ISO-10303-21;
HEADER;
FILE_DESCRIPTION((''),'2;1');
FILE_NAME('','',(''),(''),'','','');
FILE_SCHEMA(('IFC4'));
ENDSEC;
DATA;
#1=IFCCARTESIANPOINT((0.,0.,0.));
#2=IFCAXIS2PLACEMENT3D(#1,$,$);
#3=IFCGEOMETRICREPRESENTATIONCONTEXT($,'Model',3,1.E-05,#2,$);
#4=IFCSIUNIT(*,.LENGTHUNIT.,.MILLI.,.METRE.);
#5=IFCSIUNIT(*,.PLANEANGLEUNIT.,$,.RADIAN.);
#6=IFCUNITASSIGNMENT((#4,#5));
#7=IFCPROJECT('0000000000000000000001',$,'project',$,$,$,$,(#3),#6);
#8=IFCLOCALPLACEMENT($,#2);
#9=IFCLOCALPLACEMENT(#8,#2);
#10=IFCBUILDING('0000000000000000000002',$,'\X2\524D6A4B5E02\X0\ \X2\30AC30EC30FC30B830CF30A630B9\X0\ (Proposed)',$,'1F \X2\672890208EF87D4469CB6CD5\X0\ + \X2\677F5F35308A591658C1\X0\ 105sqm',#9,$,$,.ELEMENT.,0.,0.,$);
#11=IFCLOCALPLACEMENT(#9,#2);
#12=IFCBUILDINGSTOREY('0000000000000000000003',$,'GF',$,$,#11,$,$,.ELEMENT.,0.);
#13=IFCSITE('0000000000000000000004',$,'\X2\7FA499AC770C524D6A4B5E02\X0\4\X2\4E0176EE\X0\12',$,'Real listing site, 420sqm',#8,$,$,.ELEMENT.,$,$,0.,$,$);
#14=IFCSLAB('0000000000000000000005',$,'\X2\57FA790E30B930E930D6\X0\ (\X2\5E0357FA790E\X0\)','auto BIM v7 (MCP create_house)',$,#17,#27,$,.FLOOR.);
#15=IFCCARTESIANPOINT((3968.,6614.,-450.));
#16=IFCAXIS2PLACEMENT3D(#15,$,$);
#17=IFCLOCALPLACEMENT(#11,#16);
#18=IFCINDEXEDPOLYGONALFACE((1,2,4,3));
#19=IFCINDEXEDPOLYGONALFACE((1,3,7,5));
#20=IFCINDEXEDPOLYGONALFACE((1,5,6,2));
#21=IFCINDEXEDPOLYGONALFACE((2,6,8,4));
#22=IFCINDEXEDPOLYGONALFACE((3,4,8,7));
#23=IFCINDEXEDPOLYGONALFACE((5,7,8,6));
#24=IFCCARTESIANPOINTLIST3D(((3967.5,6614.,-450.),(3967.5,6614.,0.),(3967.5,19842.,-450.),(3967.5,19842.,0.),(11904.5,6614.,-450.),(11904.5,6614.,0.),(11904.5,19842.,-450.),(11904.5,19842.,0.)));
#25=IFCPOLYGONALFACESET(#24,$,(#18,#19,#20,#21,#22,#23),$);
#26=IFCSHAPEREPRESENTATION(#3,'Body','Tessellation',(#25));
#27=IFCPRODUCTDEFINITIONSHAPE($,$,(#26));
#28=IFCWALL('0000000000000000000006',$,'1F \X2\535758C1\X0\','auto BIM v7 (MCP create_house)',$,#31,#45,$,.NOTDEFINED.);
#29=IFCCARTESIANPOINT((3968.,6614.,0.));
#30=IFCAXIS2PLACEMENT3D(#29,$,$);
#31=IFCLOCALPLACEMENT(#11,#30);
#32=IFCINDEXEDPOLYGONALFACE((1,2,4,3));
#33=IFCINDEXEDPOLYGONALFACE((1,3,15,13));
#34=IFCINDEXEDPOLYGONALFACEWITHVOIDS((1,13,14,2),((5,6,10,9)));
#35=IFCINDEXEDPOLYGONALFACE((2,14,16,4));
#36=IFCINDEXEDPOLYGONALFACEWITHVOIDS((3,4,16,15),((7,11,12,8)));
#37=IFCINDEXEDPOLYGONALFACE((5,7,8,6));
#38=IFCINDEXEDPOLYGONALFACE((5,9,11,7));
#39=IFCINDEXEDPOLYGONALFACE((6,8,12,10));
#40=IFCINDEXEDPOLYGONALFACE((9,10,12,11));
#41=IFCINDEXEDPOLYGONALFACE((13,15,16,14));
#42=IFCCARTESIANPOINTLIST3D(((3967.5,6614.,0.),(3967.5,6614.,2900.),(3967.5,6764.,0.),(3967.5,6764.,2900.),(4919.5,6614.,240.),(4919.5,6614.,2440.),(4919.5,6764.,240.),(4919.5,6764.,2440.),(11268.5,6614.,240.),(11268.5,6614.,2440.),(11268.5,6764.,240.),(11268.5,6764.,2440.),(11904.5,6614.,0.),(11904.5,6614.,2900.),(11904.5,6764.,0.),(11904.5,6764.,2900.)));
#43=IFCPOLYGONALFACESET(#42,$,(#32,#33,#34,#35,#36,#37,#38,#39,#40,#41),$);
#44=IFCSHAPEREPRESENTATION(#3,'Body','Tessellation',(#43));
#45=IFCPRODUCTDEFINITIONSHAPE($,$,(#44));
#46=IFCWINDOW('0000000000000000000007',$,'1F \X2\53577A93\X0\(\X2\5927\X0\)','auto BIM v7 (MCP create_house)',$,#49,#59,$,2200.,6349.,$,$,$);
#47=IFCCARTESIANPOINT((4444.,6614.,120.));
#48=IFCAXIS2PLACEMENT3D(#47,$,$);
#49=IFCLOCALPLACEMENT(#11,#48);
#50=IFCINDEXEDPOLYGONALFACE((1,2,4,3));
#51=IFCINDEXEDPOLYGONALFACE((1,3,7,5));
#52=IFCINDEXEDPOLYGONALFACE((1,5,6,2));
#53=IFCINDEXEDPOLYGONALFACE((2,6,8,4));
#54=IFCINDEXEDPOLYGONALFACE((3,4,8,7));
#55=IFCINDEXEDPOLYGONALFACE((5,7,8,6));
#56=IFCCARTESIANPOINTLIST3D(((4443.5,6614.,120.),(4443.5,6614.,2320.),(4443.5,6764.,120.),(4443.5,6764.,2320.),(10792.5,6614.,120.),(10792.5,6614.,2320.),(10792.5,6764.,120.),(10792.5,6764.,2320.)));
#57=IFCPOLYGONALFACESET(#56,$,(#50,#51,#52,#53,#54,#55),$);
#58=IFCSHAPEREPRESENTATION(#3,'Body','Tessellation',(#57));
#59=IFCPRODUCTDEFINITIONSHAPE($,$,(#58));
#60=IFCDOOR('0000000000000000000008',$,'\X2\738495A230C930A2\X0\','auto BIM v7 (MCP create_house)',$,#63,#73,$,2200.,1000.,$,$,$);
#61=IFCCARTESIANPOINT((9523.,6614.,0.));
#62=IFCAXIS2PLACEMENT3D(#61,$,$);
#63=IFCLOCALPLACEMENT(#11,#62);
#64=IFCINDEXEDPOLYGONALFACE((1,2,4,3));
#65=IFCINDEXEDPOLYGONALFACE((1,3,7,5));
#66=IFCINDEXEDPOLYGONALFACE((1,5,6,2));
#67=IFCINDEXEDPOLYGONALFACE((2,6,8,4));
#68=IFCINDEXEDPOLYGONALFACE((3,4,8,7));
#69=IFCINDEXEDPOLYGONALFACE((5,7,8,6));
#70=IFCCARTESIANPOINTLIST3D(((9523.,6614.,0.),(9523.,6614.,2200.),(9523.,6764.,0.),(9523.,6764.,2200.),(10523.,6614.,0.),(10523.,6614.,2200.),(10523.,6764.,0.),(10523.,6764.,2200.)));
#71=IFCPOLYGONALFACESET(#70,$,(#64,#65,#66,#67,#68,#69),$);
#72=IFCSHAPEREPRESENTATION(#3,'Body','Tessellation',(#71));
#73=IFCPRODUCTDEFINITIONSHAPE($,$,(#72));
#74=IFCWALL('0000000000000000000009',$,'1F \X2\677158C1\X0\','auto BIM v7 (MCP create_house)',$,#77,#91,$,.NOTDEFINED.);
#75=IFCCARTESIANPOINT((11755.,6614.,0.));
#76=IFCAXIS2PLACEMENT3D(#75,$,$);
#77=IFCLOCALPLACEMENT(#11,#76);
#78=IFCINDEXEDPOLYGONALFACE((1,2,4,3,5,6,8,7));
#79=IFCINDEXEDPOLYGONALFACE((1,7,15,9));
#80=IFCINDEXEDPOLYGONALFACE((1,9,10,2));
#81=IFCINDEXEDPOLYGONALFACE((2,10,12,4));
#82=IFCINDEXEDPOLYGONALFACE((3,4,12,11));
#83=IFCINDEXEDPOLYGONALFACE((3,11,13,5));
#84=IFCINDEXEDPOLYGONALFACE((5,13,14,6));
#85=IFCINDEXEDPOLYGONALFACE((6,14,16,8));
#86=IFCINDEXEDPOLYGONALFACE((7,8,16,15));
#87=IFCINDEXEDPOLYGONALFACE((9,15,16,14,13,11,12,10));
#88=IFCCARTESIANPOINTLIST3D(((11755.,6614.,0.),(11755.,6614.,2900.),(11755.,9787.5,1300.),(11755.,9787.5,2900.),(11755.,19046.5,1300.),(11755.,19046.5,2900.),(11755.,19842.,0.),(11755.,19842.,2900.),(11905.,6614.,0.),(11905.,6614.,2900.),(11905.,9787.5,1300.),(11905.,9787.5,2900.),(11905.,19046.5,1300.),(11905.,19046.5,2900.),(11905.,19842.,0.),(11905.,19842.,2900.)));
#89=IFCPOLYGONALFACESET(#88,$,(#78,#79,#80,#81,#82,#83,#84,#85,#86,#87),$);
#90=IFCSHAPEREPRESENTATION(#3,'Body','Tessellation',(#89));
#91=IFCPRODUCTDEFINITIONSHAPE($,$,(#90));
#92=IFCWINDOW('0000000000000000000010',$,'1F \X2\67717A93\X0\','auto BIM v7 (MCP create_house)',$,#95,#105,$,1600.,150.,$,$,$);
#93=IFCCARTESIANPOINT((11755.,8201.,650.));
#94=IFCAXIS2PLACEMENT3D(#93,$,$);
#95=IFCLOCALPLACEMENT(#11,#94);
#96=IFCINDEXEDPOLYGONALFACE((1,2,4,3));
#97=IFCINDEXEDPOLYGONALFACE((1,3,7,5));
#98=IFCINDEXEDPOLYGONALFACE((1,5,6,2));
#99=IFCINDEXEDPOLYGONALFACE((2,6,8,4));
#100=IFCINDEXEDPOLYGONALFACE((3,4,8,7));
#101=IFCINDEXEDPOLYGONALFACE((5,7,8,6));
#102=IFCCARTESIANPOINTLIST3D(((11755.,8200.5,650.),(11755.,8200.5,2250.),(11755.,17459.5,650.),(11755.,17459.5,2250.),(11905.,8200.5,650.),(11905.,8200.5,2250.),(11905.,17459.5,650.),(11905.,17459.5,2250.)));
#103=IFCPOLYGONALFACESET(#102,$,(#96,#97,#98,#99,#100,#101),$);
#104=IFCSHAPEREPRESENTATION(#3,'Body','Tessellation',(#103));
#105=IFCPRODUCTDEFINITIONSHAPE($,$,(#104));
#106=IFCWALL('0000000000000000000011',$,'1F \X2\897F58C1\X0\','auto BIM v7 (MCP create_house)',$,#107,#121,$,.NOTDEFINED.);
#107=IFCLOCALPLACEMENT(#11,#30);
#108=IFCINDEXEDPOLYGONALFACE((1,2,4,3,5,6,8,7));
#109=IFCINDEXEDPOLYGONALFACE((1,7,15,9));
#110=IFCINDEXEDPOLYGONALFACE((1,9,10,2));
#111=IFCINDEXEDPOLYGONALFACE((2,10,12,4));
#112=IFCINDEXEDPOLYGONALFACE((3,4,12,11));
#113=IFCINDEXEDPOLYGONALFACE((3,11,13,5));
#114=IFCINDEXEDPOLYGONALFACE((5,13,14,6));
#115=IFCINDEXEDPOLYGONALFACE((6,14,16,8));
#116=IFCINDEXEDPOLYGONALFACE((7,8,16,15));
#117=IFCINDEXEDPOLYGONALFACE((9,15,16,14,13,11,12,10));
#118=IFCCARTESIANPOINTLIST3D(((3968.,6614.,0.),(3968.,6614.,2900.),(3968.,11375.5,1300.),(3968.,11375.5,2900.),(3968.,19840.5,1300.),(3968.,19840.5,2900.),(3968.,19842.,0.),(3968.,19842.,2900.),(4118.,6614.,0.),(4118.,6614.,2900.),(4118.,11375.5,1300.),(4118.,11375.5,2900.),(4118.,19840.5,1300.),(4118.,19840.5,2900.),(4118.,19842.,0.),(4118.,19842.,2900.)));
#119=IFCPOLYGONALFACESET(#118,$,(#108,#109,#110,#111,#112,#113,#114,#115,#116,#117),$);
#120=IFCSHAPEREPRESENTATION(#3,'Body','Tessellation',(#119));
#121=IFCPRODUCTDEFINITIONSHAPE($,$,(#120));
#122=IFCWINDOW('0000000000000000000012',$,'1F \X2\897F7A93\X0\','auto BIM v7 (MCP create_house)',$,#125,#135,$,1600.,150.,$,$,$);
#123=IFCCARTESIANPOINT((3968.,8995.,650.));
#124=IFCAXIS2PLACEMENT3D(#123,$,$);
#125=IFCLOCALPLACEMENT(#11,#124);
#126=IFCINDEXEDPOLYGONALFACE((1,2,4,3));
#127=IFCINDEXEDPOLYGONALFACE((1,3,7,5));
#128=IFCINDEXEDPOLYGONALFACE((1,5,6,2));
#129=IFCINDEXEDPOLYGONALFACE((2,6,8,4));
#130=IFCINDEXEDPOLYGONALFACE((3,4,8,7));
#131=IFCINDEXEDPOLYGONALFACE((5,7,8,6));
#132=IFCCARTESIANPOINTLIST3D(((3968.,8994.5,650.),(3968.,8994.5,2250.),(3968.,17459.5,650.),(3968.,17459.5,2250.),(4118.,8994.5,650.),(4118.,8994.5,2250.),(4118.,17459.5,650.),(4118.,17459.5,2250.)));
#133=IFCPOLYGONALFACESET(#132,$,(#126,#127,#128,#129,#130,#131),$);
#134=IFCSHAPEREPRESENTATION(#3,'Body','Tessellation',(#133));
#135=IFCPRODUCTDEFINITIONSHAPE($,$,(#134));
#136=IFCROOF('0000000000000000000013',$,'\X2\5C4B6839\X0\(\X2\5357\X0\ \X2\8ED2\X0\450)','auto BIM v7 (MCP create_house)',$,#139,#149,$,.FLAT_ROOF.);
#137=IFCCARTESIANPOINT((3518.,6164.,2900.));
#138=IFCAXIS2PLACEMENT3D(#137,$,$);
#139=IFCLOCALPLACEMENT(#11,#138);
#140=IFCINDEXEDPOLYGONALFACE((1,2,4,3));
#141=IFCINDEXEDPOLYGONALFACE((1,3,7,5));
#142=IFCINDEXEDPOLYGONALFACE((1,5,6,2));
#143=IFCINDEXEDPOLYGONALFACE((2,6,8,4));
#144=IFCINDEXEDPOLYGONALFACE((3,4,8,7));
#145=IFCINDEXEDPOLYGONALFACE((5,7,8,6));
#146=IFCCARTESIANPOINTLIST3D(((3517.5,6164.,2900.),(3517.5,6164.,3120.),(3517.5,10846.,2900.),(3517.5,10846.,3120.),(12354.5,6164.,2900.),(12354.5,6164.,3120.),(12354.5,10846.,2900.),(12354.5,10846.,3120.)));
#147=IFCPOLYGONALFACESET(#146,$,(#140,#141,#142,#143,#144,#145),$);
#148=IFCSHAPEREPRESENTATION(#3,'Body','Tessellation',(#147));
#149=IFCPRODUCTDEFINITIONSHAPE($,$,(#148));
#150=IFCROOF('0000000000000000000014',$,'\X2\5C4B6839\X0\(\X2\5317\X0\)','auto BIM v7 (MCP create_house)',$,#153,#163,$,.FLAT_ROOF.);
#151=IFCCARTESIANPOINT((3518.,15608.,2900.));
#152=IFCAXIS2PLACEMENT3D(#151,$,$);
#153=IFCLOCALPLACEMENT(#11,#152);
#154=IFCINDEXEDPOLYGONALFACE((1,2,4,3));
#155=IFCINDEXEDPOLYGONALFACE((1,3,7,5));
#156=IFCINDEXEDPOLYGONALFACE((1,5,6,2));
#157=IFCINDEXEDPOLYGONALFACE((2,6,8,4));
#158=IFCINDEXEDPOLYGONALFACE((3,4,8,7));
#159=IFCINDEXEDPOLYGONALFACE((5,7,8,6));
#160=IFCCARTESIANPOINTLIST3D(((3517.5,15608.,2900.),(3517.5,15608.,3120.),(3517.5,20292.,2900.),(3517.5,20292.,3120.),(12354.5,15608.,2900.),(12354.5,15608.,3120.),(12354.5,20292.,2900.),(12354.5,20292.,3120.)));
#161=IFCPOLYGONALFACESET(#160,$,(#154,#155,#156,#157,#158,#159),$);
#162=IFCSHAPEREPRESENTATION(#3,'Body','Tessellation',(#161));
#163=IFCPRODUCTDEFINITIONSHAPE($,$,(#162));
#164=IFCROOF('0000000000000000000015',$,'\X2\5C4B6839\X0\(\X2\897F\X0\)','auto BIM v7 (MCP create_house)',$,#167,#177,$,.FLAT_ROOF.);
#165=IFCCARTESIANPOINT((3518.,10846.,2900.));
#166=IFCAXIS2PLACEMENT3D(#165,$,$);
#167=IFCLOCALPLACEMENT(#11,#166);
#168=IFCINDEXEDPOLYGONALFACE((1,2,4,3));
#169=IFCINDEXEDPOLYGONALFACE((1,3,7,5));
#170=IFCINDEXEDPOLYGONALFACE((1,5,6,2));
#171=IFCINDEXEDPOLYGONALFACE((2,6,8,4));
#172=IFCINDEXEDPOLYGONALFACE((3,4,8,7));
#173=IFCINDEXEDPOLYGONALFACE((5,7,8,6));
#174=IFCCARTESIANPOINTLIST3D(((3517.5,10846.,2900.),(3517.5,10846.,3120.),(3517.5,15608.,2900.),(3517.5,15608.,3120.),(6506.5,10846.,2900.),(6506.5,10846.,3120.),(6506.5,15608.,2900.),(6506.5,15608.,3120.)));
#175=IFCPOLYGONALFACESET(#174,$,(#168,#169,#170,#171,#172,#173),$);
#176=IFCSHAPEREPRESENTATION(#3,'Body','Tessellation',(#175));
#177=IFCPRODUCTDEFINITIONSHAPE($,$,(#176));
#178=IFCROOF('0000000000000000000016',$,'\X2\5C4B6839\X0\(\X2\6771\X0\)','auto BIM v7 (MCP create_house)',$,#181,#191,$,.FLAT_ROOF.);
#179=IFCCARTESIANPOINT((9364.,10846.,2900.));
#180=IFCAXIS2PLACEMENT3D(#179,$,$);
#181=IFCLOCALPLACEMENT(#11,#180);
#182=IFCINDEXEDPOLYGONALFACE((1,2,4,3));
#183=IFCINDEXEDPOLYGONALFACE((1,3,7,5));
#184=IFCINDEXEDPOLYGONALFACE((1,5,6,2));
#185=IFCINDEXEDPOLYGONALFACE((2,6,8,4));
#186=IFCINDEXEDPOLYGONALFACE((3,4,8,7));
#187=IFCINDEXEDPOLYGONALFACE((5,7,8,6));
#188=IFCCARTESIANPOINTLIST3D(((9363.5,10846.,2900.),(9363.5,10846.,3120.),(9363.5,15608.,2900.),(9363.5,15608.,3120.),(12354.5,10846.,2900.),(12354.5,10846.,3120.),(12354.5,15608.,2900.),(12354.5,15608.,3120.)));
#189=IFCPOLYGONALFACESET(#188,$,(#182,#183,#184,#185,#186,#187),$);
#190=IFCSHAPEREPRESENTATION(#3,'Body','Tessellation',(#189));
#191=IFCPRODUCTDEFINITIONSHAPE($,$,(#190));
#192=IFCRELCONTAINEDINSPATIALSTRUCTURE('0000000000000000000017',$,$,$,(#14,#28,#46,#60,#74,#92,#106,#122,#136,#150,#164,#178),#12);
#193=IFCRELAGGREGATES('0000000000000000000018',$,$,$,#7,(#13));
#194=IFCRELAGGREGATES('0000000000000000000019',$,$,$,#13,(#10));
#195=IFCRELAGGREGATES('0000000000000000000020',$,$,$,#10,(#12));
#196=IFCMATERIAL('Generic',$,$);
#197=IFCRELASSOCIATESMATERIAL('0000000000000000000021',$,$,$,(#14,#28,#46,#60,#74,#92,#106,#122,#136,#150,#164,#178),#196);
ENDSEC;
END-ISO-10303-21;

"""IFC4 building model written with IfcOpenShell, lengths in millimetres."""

from ifc_helpers import new_model, si_unit, frame, frame_2d, origin, place, context, project, spatial, rectangle, extrude, material, element, fill, save


model = new_model("IFC4")

# Units and contexts
model_context = context("Model", 3, precision=1e-05, world=origin())
ifc_project = project(units=[si_unit("LENGTHUNIT", "METRE", prefix="MILLI"), si_unit("PLANEANGLEUNIT", "RADIAN")], contexts=[model_context])

# Site, building, storey
site_placement = place(None, origin())
site = spatial("IfcSite", under=ifc_project, at=site_placement, Name="群馬県前橋市4丁目12", ObjectType="Real listing site, 420sqm", CompositionType="ELEMENT", RefElevation=0.0)
building_placement = place(site_placement, origin())
building = spatial("IfcBuilding", under=site, at=building_placement, Name="前橋市 ガレージハウス (Proposed)", ObjectType="1F 木造軸組構法 + 板張り外壁 105sqm", CompositionType="ELEMENT", ElevationOfRefHeight=0.0, ElevationOfTerrain=0.0)
storey_placement = place(building_placement, origin())
storey = spatial("IfcBuildingStorey", under=building, at=storey_placement, Name="GF", CompositionType="ELEMENT", Elevation=0.0)

# Slab
ifc_material = material(Name="Generic")
slab_1_placement = place(storey_placement, frame((3968.0, 6614.0, -450.0)))
element("IfcSlab", 1, at=slab_1_placement, inside=storey, material=ifc_material, Name="基礎スラブ (布基礎)", Description="auto BIM v7 (MCP create_house)", PredefinedType="FLOOR", context=model_context, shape_type="SweptSolid", body=[
    extrude(rectangle(XDim=7937.0, YDim=13228.0, at=frame_2d((3968.0, 6614.0))), frame((3968.0, 6614.0, -450.0)), (0.0, 0.0, 1.0), 450.0),
])

# Wall, openings, window, door
wall_1_placement = place(storey_placement, frame((3968.0, 6614.0, 0.0)))
wall_1 = element("IfcWall", 2, at=wall_1_placement, inside=storey, material=ifc_material, Name="1F 南壁", Description="auto BIM v7 (MCP create_house)", PredefinedType="NOTDEFINED", context=model_context, shape_type="SweptSolid", body=[
    extrude(rectangle(XDim=7937.0, YDim=150.0, at=frame_2d((3968.0, 75.0))), frame((3968.0, 6614.0, 0.0)), (0.0, 0.0, 1.0), 2900.0),
])
opening_1_placement = place(storey_placement, frame((4444.0, 6614.0, 120.0)))
opening_1 = element("IfcOpeningElement", 3, at=opening_1_placement, cuts=wall_1, PredefinedType="NOTDEFINED", context=model_context, shape_type="SweptSolid", body=[
    extrude(rectangle(XDim=6349.0, YDim=150.0, at=frame_2d((3174.0, 75.0))), frame((4444.0, 6614.0, 120.0)), (0.0, 0.0, 1.0), 2200.0),
])
opening_2_placement = place(storey_placement, frame((9523.0, 6614.0, 0.0)))
opening_2 = element("IfcOpeningElement", 4, at=opening_2_placement, cuts=wall_1, PredefinedType="NOTDEFINED", context=model_context, shape_type="SweptSolid", body=[
    extrude(rectangle(XDim=1000.0, YDim=150.0, at=frame_2d((500.0, 75.0))), frame((9523.0, 6614.0, 0.0)), (0.0, 0.0, 1.0), 2200.0),
])
window_1_placement = place(storey_placement, frame((4444.0, 6614.0, 120.0)))
window_1 = element("IfcWindow", 5, at=window_1_placement, inside=storey, material=ifc_material, Name="1F 南窓(大)", Description="auto BIM v7 (MCP create_house)", OverallHeight=2200.0, OverallWidth=6349.0, context=model_context, shape_type="SweptSolid", body=[
    extrude(rectangle(XDim=6349.0, YDim=150.0, at=frame_2d((3174.0, 75.0))), frame((4444.0, 6614.0, 120.0)), (0.0, 0.0, 1.0), 2200.0),
])
fill(opening_1, window_1)
door_placement = place(storey_placement, frame((9523.0, 6614.0, 0.0)))
door = element("IfcDoor", 6, at=door_placement, inside=storey, material=ifc_material, Name="玄関ドア", Description="auto BIM v7 (MCP create_house)", OverallHeight=2200.0, OverallWidth=1000.0, context=model_context, shape_type="SweptSolid", body=[
    extrude(rectangle(XDim=1000.0, YDim=150.0, at=frame_2d((500.0, 75.0))), frame((9523.0, 6614.0, 0.0)), (0.0, 0.0, 1.0), 2200.0),
])
fill(opening_2, door)

# Walls, openings, windows
wall_2_placement = place(storey_placement, frame((11755.0, 6614.0, 0.0)))
wall_2 = element("IfcWall", 7, at=wall_2_placement, inside=storey, material=ifc_material, Name="1F 東壁", Description="auto BIM v7 (MCP create_house)", PredefinedType="NOTDEFINED", context=model_context, shape_type="SweptSolid", body=[
    extrude(rectangle(XDim=150.0, YDim=13228.0, at=frame_2d((75.0, 6614.0))), frame((11755.0, 6614.0, 0.0)), (0.0, 0.0, 1.0), 2900.0),
])
opening_3_placement = place(storey_placement, frame((11755.0, 8201.0, 650.0)))
opening_3 = element("IfcOpeningElement", 8, at=opening_3_placement, cuts=wall_2, PredefinedType="NOTDEFINED", context=model_context, shape_type="SweptSolid", body=[
    extrude(rectangle(XDim=150.0, YDim=9259.0, at=frame_2d((75.0, 4629.0))), frame((11755.0, 8201.0, 650.0)), (0.0, 0.0, 1.0), 1600.0),
])
window_2_placement = place(storey_placement, frame((11755.0, 8201.0, 650.0)))
window_2 = element("IfcWindow", 9, at=window_2_placement, inside=storey, material=ifc_material, Name="1F 東窓", Description="auto BIM v7 (MCP create_house)", OverallHeight=1600.0, OverallWidth=150.0, context=model_context, shape_type="SweptSolid", body=[
    extrude(rectangle(XDim=150.0, YDim=9259.0, at=frame_2d((75.0, 4629.0))), frame((11755.0, 8201.0, 650.0)), (0.0, 0.0, 1.0), 1600.0),
])
fill(opening_3, window_2)
wall_3_placement = place(storey_placement, frame((3968.0, 6614.0, 0.0)))
wall_3 = element("IfcWall", 10, at=wall_3_placement, inside=storey, material=ifc_material, Name="1F 西壁", Description="auto BIM v7 (MCP create_house)", PredefinedType="NOTDEFINED", context=model_context, shape_type="SweptSolid", body=[
    extrude(rectangle(XDim=150.0, YDim=13228.0, at=frame_2d((75.0, 6614.0))), frame((3968.0, 6614.0, 0.0)), (0.0, 0.0, 1.0), 2900.0),
])
opening_4_placement = place(storey_placement, frame((3968.0, 8995.0, 650.0)))
opening_4 = element("IfcOpeningElement", 11, at=opening_4_placement, cuts=wall_3, PredefinedType="NOTDEFINED", context=model_context, shape_type="SweptSolid", body=[
    extrude(rectangle(XDim=150.0, YDim=8465.0, at=frame_2d((75.0, 4232.0))), frame((3968.0, 8995.0, 650.0)), (0.0, 0.0, 1.0), 1600.0),
])
window_3_placement = place(storey_placement, frame((3968.0, 8995.0, 650.0)))
window_3 = element("IfcWindow", 12, at=window_3_placement, inside=storey, material=ifc_material, Name="1F 西窓", Description="auto BIM v7 (MCP create_house)", OverallHeight=1600.0, OverallWidth=150.0, context=model_context, shape_type="SweptSolid", body=[
    extrude(rectangle(XDim=150.0, YDim=8465.0, at=frame_2d((75.0, 4232.0))), frame((3968.0, 8995.0, 650.0)), (0.0, 0.0, 1.0), 1600.0),
])
fill(opening_4, window_3)

# Roofs
roof_1_placement = place(storey_placement, frame((3518.0, 6164.0, 2900.0)))
element("IfcRoof", 13, at=roof_1_placement, inside=storey, material=ifc_material, Name="屋根(南 軒450)", Description="auto BIM v7 (MCP create_house)", PredefinedType="FLAT_ROOF", context=model_context, shape_type="SweptSolid", body=[
    extrude(rectangle(XDim=8837.0, YDim=4682.0, at=frame_2d((4418.0, 2341.0))), frame((3518.0, 6164.0, 2900.0)), (0.0, 0.0, 1.0), 220.0),
])
roof_2_placement = place(storey_placement, frame((3518.0, 15608.0, 2900.0)))
element("IfcRoof", 14, at=roof_2_placement, inside=storey, material=ifc_material, Name="屋根(北)", Description="auto BIM v7 (MCP create_house)", PredefinedType="FLAT_ROOF", context=model_context, shape_type="SweptSolid", body=[
    extrude(rectangle(XDim=8837.0, YDim=4684.0, at=frame_2d((4418.0, 2342.0))), frame((3518.0, 15608.0, 2900.0)), (0.0, 0.0, 1.0), 220.0),
])
roof_3_placement = place(storey_placement, frame((3518.0, 10846.0, 2900.0)))
element("IfcRoof", 15, at=roof_3_placement, inside=storey, material=ifc_material, Name="屋根(西)", Description="auto BIM v7 (MCP create_house)", PredefinedType="FLAT_ROOF", context=model_context, shape_type="SweptSolid", body=[
    extrude(rectangle(XDim=2989.0, YDim=4762.0, at=frame_2d((1494.0, 2381.0))), frame((3518.0, 10846.0, 2900.0)), (0.0, 0.0, 1.0), 220.0),
])
roof_4_placement = place(storey_placement, frame((9364.0, 10846.0, 2900.0)))
element("IfcRoof", 16, at=roof_4_placement, inside=storey, material=ifc_material, Name="屋根(東)", Description="auto BIM v7 (MCP create_house)", PredefinedType="FLAT_ROOF", context=model_context, shape_type="SweptSolid", body=[
    extrude(rectangle(XDim=2991.0, YDim=4762.0, at=frame_2d((1495.0, 2381.0))), frame((9364.0, 10846.0, 2900.0)), (0.0, 0.0, 1.0), 220.0),
])

save(model, "model.ifc")
